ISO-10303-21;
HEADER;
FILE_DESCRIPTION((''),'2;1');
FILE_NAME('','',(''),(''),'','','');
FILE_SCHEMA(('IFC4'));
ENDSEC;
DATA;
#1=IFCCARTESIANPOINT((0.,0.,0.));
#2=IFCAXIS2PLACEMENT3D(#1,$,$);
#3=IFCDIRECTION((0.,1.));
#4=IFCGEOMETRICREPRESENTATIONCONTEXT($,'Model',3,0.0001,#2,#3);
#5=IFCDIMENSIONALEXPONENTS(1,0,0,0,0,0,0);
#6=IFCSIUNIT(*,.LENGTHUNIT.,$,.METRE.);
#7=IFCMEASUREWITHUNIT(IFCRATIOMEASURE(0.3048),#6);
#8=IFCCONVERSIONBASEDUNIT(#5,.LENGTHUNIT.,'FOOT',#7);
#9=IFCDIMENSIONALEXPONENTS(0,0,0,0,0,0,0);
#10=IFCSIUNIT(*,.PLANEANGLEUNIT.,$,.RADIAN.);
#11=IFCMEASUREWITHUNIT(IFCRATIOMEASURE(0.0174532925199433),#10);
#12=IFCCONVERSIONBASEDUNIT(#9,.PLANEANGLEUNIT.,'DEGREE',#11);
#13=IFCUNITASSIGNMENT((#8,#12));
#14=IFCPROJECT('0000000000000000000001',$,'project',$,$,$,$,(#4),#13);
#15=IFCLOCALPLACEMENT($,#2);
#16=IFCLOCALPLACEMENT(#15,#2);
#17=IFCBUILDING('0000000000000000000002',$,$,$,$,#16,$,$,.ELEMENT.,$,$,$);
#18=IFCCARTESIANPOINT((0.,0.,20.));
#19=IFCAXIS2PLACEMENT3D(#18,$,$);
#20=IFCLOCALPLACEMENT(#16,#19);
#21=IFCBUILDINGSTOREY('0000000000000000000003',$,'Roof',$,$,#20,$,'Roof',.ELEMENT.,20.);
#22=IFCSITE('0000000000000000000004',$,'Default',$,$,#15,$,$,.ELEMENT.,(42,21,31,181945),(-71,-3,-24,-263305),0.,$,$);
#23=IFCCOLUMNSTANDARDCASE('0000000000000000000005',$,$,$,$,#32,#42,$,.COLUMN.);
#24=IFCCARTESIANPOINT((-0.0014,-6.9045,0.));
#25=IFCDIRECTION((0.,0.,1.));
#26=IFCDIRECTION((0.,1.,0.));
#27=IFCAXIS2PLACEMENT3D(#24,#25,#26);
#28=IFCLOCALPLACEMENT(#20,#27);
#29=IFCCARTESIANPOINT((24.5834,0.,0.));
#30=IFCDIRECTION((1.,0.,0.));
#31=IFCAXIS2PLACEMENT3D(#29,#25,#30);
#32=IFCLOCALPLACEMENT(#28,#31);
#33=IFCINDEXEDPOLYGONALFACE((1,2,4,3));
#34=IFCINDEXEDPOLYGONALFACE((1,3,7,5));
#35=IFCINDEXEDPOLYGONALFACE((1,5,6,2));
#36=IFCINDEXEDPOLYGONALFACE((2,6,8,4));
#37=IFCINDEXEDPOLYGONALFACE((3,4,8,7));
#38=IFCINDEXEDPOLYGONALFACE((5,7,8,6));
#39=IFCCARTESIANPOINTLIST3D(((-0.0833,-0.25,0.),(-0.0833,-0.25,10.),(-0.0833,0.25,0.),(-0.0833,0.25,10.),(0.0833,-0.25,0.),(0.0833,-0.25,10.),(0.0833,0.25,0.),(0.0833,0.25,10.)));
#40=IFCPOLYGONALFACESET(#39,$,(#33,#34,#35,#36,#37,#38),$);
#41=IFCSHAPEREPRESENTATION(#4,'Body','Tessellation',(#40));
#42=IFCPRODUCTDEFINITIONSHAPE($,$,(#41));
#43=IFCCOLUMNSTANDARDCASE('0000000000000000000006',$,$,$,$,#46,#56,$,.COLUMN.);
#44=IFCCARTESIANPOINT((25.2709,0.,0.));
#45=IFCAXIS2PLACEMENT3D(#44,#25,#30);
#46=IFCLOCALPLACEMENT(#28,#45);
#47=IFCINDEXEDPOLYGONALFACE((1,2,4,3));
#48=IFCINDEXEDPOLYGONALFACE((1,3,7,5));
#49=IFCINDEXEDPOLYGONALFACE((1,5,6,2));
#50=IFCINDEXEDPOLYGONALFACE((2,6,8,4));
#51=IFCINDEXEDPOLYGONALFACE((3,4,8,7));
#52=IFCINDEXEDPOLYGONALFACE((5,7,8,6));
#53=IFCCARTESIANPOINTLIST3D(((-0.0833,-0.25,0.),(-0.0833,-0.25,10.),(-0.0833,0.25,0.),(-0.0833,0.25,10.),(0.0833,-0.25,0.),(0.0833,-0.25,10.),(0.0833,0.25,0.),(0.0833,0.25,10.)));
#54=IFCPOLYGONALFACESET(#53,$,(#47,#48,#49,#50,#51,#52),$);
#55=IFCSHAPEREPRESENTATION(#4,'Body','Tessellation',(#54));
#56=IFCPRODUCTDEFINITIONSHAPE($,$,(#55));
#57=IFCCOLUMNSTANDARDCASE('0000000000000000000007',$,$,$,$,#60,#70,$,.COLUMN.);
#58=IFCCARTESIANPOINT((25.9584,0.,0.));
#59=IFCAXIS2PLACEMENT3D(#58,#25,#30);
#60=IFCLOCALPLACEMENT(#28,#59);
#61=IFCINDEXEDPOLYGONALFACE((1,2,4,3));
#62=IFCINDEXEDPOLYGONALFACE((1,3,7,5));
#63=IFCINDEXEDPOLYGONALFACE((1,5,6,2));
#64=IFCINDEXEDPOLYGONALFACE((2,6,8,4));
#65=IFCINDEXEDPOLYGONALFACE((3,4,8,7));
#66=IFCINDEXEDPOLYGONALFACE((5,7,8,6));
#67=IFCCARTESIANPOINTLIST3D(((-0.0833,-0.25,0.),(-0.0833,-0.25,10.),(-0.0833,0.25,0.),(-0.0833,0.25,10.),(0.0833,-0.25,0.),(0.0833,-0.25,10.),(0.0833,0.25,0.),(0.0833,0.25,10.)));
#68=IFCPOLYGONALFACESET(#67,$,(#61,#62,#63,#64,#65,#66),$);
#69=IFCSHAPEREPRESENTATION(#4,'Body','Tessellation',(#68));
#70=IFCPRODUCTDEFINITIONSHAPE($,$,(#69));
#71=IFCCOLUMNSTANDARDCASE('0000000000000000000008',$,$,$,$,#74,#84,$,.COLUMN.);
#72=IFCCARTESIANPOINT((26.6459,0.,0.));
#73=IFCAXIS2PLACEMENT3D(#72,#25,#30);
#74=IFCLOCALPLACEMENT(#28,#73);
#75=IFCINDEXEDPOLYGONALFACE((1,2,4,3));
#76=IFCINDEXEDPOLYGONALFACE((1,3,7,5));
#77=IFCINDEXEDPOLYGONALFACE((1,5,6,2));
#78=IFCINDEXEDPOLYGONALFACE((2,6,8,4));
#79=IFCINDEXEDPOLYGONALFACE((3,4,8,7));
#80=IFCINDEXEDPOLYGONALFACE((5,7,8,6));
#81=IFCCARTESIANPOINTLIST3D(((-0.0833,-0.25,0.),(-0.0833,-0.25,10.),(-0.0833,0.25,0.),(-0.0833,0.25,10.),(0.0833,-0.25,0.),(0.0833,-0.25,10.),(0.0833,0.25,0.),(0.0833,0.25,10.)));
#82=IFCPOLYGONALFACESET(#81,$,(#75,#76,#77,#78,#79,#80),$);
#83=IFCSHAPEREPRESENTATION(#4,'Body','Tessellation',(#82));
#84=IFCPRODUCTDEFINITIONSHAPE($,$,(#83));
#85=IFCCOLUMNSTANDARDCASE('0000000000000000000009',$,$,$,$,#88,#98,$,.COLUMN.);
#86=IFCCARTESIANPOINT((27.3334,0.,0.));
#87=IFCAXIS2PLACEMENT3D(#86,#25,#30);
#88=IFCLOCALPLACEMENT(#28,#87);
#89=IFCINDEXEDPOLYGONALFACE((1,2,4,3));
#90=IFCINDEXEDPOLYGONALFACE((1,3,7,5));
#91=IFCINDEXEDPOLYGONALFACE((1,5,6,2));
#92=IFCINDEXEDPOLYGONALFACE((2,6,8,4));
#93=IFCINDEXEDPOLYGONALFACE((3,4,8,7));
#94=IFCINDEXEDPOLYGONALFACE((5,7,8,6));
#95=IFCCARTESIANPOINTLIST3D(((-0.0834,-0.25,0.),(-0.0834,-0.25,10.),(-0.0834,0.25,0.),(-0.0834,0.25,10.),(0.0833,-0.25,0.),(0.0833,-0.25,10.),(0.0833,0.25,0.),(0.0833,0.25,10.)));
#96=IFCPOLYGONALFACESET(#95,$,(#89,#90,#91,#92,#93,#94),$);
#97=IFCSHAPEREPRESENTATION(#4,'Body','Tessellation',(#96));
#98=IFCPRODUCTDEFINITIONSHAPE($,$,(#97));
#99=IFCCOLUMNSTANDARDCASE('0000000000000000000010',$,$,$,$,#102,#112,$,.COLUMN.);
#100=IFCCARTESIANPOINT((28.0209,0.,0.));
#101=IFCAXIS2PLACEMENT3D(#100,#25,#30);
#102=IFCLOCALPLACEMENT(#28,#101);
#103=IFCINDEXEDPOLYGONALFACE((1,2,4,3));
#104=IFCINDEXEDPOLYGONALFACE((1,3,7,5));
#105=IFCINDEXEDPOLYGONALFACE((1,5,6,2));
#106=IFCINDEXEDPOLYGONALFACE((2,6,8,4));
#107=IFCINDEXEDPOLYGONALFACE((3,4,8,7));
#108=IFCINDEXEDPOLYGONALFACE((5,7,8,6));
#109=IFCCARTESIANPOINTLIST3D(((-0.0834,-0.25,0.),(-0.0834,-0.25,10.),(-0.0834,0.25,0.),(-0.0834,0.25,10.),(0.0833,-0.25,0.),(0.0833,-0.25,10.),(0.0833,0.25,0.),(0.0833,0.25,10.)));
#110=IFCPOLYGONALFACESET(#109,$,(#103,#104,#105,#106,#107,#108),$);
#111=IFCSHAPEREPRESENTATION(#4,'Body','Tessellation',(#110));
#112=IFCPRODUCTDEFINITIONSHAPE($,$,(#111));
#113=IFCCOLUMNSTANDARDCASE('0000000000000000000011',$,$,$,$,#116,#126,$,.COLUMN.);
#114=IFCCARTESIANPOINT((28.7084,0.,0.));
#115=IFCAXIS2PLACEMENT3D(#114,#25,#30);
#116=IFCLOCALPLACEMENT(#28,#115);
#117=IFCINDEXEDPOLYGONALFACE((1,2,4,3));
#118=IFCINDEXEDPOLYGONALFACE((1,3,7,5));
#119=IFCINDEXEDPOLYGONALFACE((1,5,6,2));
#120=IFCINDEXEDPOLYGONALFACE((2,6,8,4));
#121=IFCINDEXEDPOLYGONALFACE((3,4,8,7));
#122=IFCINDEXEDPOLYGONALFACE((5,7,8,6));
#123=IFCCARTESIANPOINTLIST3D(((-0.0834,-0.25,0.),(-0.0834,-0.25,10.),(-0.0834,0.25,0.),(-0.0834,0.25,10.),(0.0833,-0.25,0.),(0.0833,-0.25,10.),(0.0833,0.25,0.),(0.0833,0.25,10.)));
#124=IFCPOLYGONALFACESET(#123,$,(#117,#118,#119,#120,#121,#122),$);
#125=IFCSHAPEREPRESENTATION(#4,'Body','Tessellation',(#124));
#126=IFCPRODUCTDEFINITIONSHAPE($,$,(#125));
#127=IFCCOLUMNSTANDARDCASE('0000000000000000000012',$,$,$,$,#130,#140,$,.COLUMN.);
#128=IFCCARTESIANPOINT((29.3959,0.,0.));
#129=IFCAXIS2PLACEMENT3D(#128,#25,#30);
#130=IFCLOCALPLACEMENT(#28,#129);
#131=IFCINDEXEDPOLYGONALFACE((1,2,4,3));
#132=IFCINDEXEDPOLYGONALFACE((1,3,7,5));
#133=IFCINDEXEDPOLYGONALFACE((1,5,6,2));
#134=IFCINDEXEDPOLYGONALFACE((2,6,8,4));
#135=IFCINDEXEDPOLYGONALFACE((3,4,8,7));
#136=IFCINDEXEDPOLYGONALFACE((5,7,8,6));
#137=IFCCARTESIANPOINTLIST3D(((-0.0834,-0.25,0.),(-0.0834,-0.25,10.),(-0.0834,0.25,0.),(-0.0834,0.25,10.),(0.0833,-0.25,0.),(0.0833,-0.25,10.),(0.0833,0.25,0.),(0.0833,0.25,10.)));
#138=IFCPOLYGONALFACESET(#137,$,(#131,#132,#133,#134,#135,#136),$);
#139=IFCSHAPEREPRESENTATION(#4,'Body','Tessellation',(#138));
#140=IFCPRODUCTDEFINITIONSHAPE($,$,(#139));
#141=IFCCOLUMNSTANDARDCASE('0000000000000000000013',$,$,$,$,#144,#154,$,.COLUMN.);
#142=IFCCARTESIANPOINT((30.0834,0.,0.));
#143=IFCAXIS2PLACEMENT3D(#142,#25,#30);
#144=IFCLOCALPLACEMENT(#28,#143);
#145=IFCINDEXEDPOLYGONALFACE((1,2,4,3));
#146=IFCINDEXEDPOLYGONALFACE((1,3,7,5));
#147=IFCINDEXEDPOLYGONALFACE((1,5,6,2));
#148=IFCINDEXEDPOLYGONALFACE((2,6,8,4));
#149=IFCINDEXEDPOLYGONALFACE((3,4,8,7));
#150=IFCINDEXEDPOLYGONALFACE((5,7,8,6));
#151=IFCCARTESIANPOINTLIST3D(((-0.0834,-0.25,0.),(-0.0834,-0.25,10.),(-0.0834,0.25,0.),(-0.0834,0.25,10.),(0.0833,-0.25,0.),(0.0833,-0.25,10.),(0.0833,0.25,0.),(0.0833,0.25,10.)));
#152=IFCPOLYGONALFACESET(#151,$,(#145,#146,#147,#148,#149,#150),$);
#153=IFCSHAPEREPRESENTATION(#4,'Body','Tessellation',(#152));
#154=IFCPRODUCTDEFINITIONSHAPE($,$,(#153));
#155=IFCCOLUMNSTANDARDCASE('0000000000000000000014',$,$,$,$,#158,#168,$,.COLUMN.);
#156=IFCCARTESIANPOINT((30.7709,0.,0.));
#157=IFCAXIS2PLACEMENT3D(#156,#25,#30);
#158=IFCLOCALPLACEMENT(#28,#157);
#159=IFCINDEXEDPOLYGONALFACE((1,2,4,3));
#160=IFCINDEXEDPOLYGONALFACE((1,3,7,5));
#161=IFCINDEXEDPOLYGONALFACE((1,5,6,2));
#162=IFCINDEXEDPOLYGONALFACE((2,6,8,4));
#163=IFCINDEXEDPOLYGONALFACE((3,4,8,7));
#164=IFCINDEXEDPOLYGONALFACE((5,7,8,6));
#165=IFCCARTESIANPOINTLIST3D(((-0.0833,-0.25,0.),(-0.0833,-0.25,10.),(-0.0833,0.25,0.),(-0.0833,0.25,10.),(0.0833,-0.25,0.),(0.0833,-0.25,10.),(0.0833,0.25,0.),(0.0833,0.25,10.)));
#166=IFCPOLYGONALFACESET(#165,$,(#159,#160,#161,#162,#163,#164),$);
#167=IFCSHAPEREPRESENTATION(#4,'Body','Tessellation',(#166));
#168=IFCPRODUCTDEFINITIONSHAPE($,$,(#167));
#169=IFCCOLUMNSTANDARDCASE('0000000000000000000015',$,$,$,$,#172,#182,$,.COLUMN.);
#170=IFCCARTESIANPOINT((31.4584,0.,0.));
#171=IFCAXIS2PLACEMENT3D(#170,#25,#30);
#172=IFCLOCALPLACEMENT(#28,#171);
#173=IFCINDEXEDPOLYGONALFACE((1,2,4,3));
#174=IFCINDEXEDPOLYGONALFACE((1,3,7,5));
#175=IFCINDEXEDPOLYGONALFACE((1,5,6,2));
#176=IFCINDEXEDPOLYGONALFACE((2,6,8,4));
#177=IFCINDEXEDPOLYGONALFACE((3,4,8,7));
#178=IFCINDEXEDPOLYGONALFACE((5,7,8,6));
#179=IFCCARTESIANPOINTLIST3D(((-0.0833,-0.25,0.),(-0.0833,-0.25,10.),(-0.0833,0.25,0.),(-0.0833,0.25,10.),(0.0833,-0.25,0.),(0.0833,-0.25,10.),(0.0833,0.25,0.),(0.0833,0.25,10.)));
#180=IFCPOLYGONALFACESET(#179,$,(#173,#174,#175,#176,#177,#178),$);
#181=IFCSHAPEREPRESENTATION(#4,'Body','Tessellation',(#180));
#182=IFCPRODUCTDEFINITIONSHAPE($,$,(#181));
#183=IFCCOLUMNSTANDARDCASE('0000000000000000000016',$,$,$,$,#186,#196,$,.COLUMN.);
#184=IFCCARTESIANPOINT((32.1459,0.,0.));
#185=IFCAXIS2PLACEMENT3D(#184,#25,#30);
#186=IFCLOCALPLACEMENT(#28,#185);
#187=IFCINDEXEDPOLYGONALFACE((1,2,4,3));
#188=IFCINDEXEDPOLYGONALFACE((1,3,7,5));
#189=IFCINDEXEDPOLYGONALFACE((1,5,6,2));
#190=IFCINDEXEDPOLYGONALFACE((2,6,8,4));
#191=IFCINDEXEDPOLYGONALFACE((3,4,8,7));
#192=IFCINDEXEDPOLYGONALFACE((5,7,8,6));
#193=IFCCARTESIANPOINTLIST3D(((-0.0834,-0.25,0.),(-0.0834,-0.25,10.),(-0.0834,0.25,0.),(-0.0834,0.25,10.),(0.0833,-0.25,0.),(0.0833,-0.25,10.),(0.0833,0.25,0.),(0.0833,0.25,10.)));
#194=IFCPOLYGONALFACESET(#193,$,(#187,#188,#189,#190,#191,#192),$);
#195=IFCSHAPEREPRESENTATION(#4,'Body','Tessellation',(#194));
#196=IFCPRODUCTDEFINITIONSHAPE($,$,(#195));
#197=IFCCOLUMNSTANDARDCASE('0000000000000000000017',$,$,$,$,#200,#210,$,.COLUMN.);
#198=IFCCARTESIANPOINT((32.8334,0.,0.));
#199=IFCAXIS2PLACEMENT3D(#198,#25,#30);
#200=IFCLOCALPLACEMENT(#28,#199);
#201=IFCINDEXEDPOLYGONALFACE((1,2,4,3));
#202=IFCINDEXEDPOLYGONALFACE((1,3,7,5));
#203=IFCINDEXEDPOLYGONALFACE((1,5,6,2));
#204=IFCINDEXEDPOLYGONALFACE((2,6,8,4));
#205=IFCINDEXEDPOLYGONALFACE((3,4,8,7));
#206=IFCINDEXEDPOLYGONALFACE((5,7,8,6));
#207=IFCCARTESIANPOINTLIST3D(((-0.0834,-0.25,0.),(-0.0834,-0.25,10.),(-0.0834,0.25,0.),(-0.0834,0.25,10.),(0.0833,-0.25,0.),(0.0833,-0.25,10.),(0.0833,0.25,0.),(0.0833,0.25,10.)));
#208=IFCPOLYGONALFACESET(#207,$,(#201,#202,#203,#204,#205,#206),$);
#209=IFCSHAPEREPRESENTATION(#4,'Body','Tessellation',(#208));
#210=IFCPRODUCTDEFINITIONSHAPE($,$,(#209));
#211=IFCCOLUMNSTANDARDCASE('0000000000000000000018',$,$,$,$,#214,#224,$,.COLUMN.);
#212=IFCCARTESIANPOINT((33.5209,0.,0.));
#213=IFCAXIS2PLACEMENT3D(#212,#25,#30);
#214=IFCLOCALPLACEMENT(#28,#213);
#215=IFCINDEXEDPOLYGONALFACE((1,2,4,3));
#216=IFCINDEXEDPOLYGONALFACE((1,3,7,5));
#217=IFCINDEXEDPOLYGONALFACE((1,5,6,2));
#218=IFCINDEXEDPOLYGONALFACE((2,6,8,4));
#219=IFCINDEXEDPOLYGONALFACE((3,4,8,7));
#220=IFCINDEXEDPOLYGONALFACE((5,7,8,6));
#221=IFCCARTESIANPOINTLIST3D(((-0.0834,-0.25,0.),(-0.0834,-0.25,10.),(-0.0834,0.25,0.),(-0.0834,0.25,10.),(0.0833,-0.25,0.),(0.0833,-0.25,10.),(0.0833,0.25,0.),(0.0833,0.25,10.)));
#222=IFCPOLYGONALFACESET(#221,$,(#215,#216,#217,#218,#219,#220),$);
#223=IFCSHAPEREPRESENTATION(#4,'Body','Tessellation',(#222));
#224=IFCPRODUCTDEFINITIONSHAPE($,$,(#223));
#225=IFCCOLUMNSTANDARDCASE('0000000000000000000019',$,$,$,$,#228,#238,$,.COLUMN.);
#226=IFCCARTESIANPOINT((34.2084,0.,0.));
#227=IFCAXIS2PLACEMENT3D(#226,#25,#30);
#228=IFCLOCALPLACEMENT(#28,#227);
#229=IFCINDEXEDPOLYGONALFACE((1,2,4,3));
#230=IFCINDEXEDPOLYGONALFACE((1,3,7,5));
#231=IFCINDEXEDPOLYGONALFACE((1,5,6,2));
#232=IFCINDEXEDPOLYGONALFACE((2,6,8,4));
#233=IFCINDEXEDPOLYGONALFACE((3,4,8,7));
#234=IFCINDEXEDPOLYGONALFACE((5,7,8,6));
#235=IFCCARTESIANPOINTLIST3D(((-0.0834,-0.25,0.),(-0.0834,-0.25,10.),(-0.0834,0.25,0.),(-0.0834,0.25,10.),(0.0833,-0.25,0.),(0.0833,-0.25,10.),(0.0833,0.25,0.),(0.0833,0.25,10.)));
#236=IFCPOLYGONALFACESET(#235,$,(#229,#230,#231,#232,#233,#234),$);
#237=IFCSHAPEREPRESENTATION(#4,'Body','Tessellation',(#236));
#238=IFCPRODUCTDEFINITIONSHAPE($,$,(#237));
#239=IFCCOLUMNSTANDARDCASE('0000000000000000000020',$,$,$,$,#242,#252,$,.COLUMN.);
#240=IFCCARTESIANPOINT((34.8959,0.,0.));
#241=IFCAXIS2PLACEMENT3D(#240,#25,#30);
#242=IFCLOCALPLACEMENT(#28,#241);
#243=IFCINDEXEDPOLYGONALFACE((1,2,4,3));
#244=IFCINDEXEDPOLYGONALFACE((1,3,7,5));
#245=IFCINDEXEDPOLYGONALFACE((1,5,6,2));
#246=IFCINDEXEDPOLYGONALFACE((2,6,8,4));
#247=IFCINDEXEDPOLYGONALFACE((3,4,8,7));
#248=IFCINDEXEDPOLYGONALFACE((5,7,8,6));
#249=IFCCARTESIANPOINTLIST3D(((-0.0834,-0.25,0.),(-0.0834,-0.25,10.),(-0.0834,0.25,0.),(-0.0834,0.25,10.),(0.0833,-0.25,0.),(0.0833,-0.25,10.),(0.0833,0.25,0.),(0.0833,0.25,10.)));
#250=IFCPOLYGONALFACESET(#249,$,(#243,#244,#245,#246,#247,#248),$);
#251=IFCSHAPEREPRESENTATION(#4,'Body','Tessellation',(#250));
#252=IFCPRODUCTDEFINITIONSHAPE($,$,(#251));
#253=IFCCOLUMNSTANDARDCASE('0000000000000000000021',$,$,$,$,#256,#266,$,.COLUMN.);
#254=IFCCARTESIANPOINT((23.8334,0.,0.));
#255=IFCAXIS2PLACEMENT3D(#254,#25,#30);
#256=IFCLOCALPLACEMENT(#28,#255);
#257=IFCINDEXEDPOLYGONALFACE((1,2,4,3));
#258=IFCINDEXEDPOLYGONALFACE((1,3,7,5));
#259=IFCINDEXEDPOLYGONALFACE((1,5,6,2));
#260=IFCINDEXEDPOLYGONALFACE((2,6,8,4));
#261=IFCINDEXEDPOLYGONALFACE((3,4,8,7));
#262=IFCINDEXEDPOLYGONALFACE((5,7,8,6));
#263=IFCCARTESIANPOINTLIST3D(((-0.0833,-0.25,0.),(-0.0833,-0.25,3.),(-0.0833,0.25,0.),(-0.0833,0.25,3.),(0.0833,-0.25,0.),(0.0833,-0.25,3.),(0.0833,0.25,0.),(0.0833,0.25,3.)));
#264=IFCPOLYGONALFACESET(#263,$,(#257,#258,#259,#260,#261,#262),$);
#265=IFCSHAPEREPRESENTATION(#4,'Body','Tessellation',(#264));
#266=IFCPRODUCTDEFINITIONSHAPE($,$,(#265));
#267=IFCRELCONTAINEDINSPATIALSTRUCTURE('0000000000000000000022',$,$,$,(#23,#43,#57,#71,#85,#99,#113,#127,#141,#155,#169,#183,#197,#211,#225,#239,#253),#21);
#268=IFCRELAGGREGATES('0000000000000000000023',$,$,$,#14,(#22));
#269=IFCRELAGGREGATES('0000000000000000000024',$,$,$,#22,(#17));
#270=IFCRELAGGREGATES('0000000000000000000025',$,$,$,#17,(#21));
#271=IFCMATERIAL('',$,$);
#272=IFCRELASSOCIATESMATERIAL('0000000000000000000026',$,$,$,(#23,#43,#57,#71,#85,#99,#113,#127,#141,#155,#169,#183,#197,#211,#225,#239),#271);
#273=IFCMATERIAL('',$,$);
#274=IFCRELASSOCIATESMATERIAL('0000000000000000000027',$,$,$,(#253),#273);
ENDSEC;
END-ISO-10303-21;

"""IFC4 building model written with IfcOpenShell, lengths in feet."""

from ifc_helpers import new_model, entity, si_unit, converted_unit, direction, frame, origin, place, context, project, spatial, rectangle, extrude, material, element, save


model = new_model("IFC4")

# Units and contexts
model_context = context("Model", 3, precision=0.0001, world=origin(), true_north=direction((0.0, 1.0)))
ifc_project = project(units=[converted_unit("LENGTHUNIT", "FOOT", entity("IfcRatioMeasure", 0.3048), si_unit("LENGTHUNIT", "METRE"), dimensions=[1, 0, 0, 0, 0, 0, 0]), converted_unit("PLANEANGLEUNIT", "DEGREE", entity("IfcRatioMeasure", 0.0174532925199433), si_unit("PLANEANGLEUNIT", "RADIAN"), dimensions=[0, 0, 0, 0, 0, 0, 0])], contexts=[model_context])

# Site, building, storey
site_placement = place(None, origin())
site = spatial("IfcSite", under=ifc_project, at=site_placement, Name="Default", CompositionType="ELEMENT", RefLatitude=(42, 21, 31, 181945), RefLongitude=(-71, -3, -24, -263305), RefElevation=0.0)
building_placement = place(site_placement, origin())
building = spatial("IfcBuilding", under=site, at=building_placement, CompositionType="ELEMENT")
storey_placement = place(building_placement, frame((0.0, 0.0, 20.0)))
storey = spatial("IfcBuildingStorey", under=building, at=storey_placement, Name="Roof", LongName="Roof", CompositionType="ELEMENT", Elevation=20.0)

# Columns
ifc_material_1 = material(Name="")
placement_1 = place(storey_placement, frame((-0.0014, -6.9045, 0.0), z_axis=(0.0, 0.0, 1.0), x_axis=(0.0, 1.0, 0.0)))
for number, where, z_axis, x_axis in (
    (1, (24.5834, 0.0, 0.0), (0.0, 0.0, 1.0), (1.0, 0.0, 0.0)),
    (2, (25.2709, 0.0, 0.0), (0.0, 0.0, 1.0), (1.0, 0.0, 0.0)),
    (3, (25.9584, 0.0, 0.0), (0.0, 0.0, 1.0), (1.0, 0.0, 0.0)),
    (4, (26.6459, 0.0, 0.0), (0.0, 0.0, 1.0), (1.0, 0.0, 0.0)),
    (5, (27.3334, 0.0, 0.0), (0.0, 0.0, 1.0), (1.0, 0.0, 0.0)),
    (6, (28.0209, 0.0, 0.0), (0.0, 0.0, 1.0), (1.0, 0.0, 0.0)),
    (7, (28.7084, 0.0, 0.0), (0.0, 0.0, 1.0), (1.0, 0.0, 0.0)),
    (8, (29.3959, 0.0, 0.0), (0.0, 0.0, 1.0), (1.0, 0.0, 0.0)),
    (9, (30.0834, 0.0, 0.0), (0.0, 0.0, 1.0), (1.0, 0.0, 0.0)),
    (10, (30.7709, 0.0, 0.0), (0.0, 0.0, 1.0), (1.0, 0.0, 0.0)),
    (11, (31.4584, 0.0, 0.0), (0.0, 0.0, 1.0), (1.0, 0.0, 0.0)),
    (12, (32.1459, 0.0, 0.0), (0.0, 0.0, 1.0), (1.0, 0.0, 0.0)),
    (13, (32.8334, 0.0, 0.0), (0.0, 0.0, 1.0), (1.0, 0.0, 0.0)),
    (14, (33.5209, 0.0, 0.0), (0.0, 0.0, 1.0), (1.0, 0.0, 0.0)),
    (15, (34.2084, 0.0, 0.0), (0.0, 0.0, 1.0), (1.0, 0.0, 0.0)),
    (16, (34.8959, 0.0, 0.0), (0.0, 0.0, 1.0), (1.0, 0.0, 0.0)),
):
    element("IfcColumnStandardCase", number, at=place(placement_1, frame(where, z_axis=z_axis, x_axis=x_axis)), inside=storey, material=ifc_material_1, PredefinedType="COLUMN", context=model_context, shape_type="SweptSolid", body=[
        extrude(rectangle(XDim=0.1667, YDim=0.5), origin(), (0.0, 0.0, 1.0), 10.0),
    ])
ifc_material_2 = material(Name="")
for number, where, z_axis, x_axis in (
    (17, (23.8334, 0.0, 0.0), (0.0, 0.0, 1.0), (1.0, 0.0, 0.0)),
):
    element("IfcColumnStandardCase", number, at=place(placement_1, frame(where, z_axis=z_axis, x_axis=x_axis)), inside=storey, material=ifc_material_2, PredefinedType="COLUMN", context=model_context, shape_type="SweptSolid", body=[
        extrude(rectangle(XDim=0.1667, YDim=0.5), origin(), (0.0, 0.0, 1.0), 3.0),
    ])

save(model, "model.ifc")
